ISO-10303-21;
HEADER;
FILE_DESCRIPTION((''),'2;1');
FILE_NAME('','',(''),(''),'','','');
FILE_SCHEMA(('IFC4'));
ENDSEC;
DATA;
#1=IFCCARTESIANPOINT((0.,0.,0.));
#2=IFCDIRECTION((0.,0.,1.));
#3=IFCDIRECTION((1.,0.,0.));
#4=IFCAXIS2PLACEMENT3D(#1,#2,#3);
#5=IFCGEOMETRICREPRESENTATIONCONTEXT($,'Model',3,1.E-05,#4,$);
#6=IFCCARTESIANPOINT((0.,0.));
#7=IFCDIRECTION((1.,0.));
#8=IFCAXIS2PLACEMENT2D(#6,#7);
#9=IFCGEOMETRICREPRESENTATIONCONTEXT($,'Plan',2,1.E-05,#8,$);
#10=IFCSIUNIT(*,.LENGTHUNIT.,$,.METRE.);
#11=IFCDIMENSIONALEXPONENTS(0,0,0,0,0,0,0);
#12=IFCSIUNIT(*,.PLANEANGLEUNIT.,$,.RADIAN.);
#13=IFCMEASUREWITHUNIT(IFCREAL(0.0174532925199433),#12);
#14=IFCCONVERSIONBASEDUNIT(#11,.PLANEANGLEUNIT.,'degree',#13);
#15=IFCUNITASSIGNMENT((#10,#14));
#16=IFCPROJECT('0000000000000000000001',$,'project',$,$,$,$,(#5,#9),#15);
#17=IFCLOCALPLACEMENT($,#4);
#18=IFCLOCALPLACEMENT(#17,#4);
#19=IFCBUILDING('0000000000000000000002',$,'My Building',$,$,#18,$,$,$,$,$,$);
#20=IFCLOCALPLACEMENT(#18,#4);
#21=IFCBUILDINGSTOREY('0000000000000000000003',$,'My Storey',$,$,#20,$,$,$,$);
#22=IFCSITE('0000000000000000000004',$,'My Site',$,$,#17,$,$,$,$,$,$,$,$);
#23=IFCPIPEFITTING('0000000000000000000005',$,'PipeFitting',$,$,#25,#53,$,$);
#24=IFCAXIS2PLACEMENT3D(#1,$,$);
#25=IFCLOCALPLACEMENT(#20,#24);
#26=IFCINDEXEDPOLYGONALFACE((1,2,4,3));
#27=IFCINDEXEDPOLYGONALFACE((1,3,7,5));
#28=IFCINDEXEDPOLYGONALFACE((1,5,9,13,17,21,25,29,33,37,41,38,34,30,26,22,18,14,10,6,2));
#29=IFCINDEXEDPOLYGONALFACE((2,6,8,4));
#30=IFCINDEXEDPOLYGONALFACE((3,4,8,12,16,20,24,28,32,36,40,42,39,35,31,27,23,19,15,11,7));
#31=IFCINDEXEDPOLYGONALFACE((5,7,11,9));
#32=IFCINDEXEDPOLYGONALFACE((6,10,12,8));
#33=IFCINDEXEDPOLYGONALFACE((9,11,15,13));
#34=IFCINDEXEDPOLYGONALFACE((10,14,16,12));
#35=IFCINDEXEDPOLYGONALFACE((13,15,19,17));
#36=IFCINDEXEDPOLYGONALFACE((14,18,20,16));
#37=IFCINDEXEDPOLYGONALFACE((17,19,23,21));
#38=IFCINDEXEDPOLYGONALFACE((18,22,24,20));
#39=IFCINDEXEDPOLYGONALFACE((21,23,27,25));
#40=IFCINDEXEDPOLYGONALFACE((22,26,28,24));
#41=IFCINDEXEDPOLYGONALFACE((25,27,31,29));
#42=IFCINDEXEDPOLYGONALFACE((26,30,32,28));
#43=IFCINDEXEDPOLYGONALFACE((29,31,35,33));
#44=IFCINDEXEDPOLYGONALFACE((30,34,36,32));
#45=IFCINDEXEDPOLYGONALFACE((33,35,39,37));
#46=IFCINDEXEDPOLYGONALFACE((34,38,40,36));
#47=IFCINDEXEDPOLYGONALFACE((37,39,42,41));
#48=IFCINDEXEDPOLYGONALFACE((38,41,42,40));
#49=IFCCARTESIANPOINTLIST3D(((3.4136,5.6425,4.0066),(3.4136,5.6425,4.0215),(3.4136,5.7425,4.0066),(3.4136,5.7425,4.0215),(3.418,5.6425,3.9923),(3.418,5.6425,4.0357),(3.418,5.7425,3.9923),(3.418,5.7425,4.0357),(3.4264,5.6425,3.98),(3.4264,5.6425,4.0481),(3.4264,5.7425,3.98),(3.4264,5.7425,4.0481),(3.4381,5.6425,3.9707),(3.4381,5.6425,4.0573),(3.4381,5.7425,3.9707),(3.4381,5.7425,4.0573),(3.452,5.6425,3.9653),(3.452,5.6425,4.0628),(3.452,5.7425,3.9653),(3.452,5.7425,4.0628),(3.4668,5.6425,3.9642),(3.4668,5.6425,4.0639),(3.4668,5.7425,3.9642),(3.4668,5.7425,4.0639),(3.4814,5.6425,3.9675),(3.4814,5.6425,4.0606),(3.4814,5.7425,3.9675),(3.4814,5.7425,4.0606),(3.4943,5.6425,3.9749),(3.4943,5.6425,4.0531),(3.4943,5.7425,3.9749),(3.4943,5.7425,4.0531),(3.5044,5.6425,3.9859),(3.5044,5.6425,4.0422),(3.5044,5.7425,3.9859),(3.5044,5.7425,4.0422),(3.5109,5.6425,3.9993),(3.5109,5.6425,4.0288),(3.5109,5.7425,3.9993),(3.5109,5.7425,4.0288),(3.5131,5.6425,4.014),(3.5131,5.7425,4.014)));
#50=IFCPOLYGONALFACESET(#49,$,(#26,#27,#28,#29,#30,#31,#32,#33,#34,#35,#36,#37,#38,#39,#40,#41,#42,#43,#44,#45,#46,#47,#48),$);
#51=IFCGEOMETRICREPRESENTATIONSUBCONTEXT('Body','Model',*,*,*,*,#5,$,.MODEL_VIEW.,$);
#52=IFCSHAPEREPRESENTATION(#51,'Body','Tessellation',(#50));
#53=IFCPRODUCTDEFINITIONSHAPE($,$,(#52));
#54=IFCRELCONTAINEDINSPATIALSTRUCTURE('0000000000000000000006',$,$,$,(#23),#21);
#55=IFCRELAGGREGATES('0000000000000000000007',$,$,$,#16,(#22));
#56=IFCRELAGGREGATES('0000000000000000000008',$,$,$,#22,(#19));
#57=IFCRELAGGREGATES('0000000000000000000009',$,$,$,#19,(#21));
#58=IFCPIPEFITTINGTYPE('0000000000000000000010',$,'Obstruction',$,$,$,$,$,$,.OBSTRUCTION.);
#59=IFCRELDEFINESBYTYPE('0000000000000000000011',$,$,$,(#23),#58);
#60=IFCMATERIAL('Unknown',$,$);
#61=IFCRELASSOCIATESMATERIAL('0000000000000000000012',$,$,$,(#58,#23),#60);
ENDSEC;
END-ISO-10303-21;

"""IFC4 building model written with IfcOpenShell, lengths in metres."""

from ifc_helpers import new_model, entity, si_unit, converted_unit, frame, origin_with_axes, origin_2d_with_axis, place, context, subcontext, project, spatial, circle, extrude, material, material_profile, profile_set, profile_usage, type_object, element, save


model = new_model("IFC4")

# Units and contexts
model_context = context("Model", 3, precision=1e-05, world=origin_with_axes())
plan_context = context("Plan", 2, precision=1e-05, world=origin_2d_with_axis())
body_context = subcontext(model_context, "Body", "Model", "MODEL_VIEW")
ifc_project = project(units=[si_unit("LENGTHUNIT", "METRE"), converted_unit("PLANEANGLEUNIT", "degree", entity("IfcReal", 0.0174532925199433), si_unit("PLANEANGLEUNIT", "RADIAN"), dimensions=[0, 0, 0, 0, 0, 0, 0])], contexts=[model_context, plan_context])

# Site, building, storey
site_placement = place(None, origin_with_axes())
site = spatial("IfcSite", under=ifc_project, at=site_placement, Name="My Site")
building_placement = place(site_placement, origin_with_axes())
building = spatial("IfcBuilding", under=site, at=building_placement, Name="My Building")
storey_placement = place(building_placement, origin_with_axes())
storey = spatial("IfcBuildingStorey", under=building, at=storey_placement, Name="My Storey")

# Shared definitions
ifc_material = material(Name="Unknown")

# Pipe fitting
ifc_material_profile_1 = material_profile(ifc_material, circle(Radius=0.05))
ifc_profile_set_1 = profile_set([ifc_material_profile_1])
pipe_fitting_type_1 = type_object("IfcPipeFittingType", Name="Obstruction", PredefinedType="OBSTRUCTION", material=ifc_profile_set_1)
ifc_profile_usage_1 = profile_usage(ifc_profile_set_1, cardinal=5)
pipe_fitting_1_placement = place(storey_placement, frame((3.4631, 5.7425, 4.014), z_axis=(0.0, -1.0, 0.0), x_axis=(1.0, 0.0, 0.0)))
element("IfcPipeFitting", 1, at=pipe_fitting_1_placement, inside=storey, type_object=pipe_fitting_type_1, material=ifc_profile_usage_1, Name="PipeFitting", context=body_context, shape_type="SweptSolid", body=[
    extrude(circle(Radius=0.05), origin_with_axes(), (0.0, 0.0, 1.0), 0.1),
])

save(model, "model.ifc")
